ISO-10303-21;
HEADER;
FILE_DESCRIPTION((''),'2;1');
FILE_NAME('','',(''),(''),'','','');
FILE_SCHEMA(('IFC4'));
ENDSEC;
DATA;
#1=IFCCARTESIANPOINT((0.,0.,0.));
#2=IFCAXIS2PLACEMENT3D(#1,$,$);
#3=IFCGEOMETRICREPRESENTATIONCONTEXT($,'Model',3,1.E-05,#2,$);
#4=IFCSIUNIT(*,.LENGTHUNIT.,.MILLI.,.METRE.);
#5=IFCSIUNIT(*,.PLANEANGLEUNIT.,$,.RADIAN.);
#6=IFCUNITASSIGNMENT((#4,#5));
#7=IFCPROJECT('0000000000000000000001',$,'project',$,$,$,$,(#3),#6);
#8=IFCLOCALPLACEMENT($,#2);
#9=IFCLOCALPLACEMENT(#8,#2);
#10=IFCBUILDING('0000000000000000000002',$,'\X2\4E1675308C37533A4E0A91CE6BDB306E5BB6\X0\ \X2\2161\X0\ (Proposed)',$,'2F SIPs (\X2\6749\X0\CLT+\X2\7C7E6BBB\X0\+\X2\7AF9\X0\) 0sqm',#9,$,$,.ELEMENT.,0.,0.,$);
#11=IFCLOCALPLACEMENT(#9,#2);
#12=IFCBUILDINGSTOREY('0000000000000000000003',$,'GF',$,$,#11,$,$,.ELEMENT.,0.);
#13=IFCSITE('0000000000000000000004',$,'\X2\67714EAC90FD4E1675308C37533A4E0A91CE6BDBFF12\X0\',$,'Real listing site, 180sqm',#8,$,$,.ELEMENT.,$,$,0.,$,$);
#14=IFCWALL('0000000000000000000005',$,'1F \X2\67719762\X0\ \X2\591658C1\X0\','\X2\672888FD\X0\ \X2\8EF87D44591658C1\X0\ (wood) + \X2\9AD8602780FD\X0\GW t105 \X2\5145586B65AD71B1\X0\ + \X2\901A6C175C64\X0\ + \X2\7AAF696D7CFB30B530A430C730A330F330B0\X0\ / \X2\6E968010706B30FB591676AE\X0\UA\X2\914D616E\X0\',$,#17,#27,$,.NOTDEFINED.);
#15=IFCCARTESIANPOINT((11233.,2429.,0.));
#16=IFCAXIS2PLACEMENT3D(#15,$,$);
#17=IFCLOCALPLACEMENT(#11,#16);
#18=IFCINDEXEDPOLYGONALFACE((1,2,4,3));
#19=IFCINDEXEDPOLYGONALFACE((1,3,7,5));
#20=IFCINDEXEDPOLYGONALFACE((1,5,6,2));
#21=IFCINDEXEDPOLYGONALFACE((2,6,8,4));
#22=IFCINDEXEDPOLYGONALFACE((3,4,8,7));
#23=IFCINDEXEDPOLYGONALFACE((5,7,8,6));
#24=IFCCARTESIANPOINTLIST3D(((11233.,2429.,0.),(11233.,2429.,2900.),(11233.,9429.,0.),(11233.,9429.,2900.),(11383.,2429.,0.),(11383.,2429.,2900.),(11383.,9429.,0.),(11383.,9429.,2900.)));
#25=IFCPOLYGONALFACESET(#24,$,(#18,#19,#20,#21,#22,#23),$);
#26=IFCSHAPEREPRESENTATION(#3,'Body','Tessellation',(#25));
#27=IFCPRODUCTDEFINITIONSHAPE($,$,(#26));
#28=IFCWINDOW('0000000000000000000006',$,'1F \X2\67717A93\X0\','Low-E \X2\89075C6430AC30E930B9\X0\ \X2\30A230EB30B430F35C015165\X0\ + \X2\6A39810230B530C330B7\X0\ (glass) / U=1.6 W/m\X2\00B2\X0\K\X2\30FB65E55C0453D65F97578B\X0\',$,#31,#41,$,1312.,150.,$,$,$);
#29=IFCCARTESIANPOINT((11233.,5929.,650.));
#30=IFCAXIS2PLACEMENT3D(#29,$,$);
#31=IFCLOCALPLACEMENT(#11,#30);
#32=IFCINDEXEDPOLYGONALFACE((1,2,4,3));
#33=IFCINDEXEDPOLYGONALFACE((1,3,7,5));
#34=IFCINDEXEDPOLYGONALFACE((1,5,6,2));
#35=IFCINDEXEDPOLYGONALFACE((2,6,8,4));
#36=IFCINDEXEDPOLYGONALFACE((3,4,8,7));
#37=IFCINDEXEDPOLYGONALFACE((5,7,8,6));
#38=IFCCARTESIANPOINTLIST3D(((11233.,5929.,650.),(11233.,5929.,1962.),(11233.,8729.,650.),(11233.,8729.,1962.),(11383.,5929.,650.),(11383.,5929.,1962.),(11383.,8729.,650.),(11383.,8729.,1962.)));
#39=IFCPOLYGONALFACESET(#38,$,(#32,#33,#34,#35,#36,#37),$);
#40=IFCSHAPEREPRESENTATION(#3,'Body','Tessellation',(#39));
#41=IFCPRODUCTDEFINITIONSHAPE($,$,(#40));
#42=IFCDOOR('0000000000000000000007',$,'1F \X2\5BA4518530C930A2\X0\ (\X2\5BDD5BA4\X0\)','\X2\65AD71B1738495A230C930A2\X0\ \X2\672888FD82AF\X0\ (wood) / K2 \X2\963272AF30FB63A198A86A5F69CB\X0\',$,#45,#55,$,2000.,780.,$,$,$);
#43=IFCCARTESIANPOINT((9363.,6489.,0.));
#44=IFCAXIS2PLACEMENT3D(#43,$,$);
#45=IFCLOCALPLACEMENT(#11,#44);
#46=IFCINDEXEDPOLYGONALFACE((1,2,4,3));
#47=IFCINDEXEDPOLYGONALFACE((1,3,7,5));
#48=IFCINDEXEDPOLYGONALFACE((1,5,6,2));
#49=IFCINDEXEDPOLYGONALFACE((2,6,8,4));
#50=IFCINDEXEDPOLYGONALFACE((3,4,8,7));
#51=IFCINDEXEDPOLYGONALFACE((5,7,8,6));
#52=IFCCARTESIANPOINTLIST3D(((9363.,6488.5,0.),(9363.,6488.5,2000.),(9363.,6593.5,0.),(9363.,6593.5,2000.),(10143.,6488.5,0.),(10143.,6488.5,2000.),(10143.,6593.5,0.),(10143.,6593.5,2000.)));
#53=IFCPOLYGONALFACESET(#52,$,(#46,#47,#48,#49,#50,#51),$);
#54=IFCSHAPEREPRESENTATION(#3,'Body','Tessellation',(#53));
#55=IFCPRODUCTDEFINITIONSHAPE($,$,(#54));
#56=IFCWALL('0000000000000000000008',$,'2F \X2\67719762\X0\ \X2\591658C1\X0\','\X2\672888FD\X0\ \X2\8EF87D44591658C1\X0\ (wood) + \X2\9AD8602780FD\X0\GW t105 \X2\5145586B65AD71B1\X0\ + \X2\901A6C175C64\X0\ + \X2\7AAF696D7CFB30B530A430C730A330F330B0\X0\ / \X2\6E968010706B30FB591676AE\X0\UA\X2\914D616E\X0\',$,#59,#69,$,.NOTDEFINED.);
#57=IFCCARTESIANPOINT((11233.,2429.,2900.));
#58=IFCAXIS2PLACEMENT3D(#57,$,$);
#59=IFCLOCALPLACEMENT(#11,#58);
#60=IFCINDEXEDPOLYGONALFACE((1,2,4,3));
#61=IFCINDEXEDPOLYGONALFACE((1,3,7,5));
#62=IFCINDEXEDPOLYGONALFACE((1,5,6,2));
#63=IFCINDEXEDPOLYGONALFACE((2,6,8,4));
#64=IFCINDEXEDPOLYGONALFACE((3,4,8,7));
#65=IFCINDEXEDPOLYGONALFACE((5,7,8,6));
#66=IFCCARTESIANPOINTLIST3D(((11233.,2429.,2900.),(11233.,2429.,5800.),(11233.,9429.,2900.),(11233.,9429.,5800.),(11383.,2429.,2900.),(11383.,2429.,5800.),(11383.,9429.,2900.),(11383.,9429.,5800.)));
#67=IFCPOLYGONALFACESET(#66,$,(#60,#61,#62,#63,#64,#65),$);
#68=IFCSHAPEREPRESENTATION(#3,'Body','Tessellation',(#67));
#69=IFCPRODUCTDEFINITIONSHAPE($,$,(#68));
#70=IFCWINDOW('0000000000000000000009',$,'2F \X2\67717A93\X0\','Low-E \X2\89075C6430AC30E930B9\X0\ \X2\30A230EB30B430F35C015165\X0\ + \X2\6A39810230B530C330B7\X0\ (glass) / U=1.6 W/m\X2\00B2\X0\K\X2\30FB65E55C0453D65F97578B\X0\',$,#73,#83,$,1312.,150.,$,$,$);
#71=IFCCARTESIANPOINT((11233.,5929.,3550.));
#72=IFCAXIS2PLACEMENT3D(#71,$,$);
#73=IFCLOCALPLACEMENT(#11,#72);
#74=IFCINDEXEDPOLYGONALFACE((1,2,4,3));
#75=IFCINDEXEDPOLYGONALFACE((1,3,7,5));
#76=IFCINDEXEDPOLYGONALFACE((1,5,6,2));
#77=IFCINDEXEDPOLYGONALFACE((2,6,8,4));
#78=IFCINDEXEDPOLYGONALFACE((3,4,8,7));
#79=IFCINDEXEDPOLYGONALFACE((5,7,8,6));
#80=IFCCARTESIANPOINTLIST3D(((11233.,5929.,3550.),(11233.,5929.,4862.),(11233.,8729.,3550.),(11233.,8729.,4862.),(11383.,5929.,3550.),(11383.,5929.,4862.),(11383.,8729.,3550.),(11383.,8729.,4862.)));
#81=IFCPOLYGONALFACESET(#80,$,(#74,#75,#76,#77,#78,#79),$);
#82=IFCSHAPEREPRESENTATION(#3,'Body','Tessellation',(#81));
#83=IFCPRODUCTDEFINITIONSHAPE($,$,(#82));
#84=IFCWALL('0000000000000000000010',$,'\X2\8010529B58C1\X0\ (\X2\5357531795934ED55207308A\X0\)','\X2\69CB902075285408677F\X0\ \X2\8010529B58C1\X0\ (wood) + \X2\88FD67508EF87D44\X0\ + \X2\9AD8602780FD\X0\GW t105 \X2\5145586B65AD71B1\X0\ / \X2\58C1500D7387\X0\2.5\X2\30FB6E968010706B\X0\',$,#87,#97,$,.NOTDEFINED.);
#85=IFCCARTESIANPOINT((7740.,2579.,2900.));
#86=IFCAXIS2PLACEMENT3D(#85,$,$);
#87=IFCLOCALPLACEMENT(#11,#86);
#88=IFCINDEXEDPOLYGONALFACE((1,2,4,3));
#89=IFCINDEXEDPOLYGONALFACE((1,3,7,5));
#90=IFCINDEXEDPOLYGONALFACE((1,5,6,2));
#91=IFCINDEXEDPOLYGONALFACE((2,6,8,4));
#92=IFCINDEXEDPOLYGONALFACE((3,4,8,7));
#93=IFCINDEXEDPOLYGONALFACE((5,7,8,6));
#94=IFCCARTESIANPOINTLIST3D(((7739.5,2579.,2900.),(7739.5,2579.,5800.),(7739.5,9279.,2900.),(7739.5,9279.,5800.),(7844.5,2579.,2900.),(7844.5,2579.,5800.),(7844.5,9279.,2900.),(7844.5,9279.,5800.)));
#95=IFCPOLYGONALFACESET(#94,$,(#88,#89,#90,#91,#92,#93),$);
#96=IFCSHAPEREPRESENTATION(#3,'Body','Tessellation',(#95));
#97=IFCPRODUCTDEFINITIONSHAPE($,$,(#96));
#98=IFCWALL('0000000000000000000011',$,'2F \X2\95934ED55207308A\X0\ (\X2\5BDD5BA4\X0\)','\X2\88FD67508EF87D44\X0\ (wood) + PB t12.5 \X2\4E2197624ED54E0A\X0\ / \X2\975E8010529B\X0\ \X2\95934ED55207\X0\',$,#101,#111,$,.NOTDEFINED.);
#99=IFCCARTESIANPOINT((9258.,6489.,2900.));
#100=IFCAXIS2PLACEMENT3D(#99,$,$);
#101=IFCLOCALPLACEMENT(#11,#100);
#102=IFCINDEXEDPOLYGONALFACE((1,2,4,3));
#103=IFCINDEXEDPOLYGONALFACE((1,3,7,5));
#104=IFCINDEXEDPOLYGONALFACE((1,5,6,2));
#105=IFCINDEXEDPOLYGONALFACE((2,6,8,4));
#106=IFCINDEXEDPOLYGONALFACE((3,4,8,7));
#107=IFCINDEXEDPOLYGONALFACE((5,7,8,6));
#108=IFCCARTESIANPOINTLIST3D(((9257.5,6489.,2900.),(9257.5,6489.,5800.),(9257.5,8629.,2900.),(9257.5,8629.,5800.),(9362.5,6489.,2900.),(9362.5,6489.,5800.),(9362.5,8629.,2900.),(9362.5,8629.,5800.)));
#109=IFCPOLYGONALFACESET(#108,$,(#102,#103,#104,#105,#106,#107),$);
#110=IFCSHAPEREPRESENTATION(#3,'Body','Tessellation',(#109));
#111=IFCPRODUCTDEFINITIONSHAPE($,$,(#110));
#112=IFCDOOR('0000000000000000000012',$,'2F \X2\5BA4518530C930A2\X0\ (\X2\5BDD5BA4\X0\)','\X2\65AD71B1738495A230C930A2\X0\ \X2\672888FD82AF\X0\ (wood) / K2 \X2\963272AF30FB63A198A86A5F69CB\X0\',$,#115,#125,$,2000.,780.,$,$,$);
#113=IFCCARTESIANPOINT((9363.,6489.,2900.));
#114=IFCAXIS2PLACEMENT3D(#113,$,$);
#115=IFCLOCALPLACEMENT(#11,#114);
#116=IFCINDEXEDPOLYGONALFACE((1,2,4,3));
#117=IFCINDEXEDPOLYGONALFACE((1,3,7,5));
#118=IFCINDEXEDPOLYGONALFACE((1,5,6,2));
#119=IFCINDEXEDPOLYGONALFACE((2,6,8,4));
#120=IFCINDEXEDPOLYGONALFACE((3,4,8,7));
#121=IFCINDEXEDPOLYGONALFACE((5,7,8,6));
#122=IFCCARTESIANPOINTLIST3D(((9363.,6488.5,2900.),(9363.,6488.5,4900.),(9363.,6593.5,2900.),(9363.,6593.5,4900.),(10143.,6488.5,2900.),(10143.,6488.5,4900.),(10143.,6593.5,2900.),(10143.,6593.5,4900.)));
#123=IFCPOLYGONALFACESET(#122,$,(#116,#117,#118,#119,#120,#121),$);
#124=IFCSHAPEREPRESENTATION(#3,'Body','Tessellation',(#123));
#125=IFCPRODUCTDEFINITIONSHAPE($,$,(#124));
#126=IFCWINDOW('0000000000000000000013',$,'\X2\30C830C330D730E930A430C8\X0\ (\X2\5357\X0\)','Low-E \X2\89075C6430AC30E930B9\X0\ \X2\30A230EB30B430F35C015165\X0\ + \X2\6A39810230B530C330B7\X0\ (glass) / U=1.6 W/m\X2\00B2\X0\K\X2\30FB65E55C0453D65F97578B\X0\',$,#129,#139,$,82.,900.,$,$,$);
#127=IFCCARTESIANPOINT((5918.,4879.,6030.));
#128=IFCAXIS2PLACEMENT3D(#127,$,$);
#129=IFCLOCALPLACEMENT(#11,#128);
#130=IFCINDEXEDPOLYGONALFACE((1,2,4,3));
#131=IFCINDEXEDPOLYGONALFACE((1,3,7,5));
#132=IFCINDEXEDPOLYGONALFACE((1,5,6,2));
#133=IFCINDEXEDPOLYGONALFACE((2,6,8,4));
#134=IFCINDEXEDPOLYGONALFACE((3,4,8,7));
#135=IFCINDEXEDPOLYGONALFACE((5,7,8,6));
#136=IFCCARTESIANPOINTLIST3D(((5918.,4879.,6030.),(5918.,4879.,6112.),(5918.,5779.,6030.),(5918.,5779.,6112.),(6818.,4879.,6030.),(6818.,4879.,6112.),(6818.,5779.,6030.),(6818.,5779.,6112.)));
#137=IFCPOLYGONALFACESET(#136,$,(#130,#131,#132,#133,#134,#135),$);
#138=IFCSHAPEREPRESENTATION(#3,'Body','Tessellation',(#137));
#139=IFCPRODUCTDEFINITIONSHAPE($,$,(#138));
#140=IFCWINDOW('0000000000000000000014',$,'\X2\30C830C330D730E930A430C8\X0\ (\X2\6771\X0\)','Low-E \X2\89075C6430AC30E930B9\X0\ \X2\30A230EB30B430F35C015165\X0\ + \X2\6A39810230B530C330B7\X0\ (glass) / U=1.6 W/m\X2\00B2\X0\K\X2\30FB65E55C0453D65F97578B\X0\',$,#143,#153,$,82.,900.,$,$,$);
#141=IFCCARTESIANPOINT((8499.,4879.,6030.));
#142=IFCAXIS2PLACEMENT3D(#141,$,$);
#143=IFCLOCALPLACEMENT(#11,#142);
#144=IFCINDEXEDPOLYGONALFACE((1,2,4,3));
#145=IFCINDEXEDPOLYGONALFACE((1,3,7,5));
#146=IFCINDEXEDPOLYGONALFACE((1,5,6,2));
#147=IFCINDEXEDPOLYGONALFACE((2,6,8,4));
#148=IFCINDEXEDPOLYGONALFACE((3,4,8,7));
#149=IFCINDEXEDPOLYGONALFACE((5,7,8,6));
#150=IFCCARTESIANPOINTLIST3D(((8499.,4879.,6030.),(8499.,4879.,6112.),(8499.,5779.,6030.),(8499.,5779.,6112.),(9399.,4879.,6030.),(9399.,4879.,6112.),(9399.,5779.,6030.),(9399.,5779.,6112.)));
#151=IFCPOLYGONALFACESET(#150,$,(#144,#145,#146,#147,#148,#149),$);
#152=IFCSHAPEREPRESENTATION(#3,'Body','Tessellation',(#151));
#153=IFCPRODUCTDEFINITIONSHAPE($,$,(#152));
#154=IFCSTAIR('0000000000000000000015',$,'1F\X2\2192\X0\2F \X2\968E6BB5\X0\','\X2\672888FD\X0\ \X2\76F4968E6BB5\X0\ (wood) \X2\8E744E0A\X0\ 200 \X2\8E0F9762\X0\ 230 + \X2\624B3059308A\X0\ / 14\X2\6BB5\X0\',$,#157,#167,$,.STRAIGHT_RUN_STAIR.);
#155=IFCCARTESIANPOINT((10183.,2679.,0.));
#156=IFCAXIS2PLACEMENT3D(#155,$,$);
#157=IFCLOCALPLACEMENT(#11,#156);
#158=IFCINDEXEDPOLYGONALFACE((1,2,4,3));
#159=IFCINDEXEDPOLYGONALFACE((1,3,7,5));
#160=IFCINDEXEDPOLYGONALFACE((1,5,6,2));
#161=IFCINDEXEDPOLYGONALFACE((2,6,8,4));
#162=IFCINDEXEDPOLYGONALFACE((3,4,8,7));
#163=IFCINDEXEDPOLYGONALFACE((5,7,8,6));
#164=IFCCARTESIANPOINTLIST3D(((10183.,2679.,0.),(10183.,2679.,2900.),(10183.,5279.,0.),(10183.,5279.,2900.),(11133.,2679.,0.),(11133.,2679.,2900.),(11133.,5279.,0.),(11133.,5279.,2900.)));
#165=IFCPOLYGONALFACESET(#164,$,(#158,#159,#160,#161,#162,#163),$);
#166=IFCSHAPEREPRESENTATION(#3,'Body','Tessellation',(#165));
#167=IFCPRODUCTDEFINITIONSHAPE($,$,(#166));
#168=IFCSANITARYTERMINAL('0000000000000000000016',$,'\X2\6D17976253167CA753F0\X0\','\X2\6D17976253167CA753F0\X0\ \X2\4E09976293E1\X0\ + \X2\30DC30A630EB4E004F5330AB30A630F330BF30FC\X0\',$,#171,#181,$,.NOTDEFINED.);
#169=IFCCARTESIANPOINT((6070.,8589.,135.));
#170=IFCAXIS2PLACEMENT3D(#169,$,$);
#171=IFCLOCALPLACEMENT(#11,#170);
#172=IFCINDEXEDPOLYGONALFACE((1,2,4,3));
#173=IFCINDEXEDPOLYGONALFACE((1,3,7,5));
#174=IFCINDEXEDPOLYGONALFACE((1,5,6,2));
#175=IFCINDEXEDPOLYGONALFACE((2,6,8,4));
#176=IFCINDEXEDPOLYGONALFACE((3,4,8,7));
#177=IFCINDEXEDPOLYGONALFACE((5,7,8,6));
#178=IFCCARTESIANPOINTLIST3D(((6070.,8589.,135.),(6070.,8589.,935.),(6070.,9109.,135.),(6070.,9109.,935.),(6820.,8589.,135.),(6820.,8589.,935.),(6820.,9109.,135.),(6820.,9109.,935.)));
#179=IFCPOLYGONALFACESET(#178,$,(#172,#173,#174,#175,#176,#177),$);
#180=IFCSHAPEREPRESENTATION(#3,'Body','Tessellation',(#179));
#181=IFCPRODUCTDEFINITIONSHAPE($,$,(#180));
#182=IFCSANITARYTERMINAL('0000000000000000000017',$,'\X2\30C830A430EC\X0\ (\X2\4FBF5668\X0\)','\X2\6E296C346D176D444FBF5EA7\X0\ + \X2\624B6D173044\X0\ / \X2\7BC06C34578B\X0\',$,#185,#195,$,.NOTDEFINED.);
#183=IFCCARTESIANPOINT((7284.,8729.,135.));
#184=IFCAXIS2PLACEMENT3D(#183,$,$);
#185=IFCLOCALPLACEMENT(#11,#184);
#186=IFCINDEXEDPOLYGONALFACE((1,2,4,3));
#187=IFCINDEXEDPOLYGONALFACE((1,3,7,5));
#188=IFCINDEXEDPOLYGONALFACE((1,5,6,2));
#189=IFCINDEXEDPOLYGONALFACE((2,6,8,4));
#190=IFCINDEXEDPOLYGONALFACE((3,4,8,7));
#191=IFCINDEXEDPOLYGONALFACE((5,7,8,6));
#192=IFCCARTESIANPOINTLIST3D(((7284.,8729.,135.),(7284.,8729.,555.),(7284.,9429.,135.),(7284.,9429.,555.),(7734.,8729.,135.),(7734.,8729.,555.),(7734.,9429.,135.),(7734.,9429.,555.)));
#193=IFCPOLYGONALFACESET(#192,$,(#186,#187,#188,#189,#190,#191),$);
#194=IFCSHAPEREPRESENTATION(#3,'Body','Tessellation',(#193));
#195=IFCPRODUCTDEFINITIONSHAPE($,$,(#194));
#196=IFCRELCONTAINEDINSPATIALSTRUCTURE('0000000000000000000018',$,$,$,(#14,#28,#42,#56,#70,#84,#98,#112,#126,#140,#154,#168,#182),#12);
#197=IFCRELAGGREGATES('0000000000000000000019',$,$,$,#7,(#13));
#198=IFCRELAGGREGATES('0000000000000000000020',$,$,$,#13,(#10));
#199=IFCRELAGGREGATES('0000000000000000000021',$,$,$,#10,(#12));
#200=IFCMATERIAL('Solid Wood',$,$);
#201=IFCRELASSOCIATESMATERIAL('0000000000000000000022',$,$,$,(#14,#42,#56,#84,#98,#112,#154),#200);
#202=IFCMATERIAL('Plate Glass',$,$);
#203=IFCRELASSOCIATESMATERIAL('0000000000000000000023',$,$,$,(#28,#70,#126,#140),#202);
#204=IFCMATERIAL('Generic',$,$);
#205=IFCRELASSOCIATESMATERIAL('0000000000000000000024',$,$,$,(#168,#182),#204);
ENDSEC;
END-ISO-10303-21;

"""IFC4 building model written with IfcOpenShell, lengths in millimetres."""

from ifc_helpers import new_model, si_unit, frame, frame_2d, origin, place, context, project, spatial, rectangle, extrude, material, element, fill, save


model = new_model("IFC4")

# Units and contexts
model_context = context("Model", 3, precision=1e-05, world=origin())
ifc_project = project(units=[si_unit("LENGTHUNIT", "METRE", prefix="MILLI"), si_unit("PLANEANGLEUNIT", "RADIAN")], contexts=[model_context])

# Site, building, storey
site_placement = place(None, origin())
site = spatial("IfcSite", under=ifc_project, at=site_placement, Name="東京都世田谷区上野毛２", ObjectType="Real listing site, 180sqm", CompositionType="ELEMENT", RefElevation=0.0)
building_placement = place(site_placement, origin())
building = spatial("IfcBuilding", under=site, at=building_placement, Name="世田谷区上野毛の家 Ⅱ (Proposed)", ObjectType="2F SIPs (杉CLT+籾殻+竹) 0sqm", CompositionType="ELEMENT", ElevationOfRefHeight=0.0, ElevationOfTerrain=0.0)
storey_placement = place(building_placement, origin())
storey = spatial("IfcBuildingStorey", under=building, at=storey_placement, Name="GF", CompositionType="ELEMENT", Elevation=0.0)

# Wall, opening, window
ifc_material_1 = material(Name="Solid Wood")
wall_1_placement = place(storey_placement, frame((11233.0, 2429.0, 0.0)))
wall_1 = element("IfcWall", 1, at=wall_1_placement, inside=storey, material=ifc_material_1, Name="1F 東面 外壁", Description="木製 軸組外壁 (wood) + 高性能GW t105 充填断熱 + 通気層 + 窯業系サイディング / 準耐火・外皮UA配慮", PredefinedType="NOTDEFINED", context=model_context, shape_type="SweptSolid", body=[
    extrude(rectangle(XDim=150.0, YDim=7000.0, at=frame_2d((75.0, 3500.0))), frame((11233.0, 2429.0, 0.0)), (0.0, 0.0, 1.0), 2900.0),
])
opening_1_placement = place(storey_placement, frame((11233.0, 5929.0, 650.0)))
opening_1 = element("IfcOpeningElement", 2, at=opening_1_placement, cuts=wall_1, PredefinedType="NOTDEFINED", context=model_context, shape_type="SweptSolid", body=[
    extrude(rectangle(XDim=150.0, YDim=2800.0, at=frame_2d((75.0, 1400.0))), frame((11233.0, 5929.0, 650.0)), (0.0, 0.0, 1.0), 1312.0),
])
ifc_material_2 = material(Name="Plate Glass")
window_1_placement = place(storey_placement, frame((11233.0, 5929.0, 650.0)))
window_1 = element("IfcWindow", 3, at=window_1_placement, inside=storey, material=ifc_material_2, Name="1F 東窓", Description="Low-E 複層ガラス アルゴン封入 + 樹脂サッシ (glass) / U=1.6 W/m²K・日射取得型", OverallHeight=1312.0, OverallWidth=150.0, context=model_context, shape_type="SweptSolid", body=[
    extrude(rectangle(XDim=150.0, YDim=2800.0, at=frame_2d((75.0, 1400.0))), frame((11233.0, 5929.0, 650.0)), (0.0, 0.0, 1.0), 1312.0),
])
fill(opening_1, window_1)

# Door
door_1_placement = place(storey_placement, frame((9363.0, 6489.0, 0.0)))
element("IfcDoor", 4, at=door_1_placement, inside=storey, material=ifc_material_1, Name="1F 室内ドア (寝室)", Description="断熱玄関ドア 木製芯 (wood) / K2 防犯・採風機構", OverallHeight=2000.0, OverallWidth=780.0, context=model_context, shape_type="SweptSolid", body=[
    extrude(rectangle(XDim=780.0, YDim=105.0, at=frame_2d((390.0, 52.0))), frame((9363.0, 6489.0, 0.0)), (0.0, 0.0, 1.0), 2000.0),
])

# Wall, opening, window
wall_2_placement = place(storey_placement, frame((11233.0, 2429.0, 2900.0)))
wall_2 = element("IfcWall", 5, at=wall_2_placement, inside=storey, material=ifc_material_1, Name="2F 東面 外壁", Description="木製 軸組外壁 (wood) + 高性能GW t105 充填断熱 + 通気層 + 窯業系サイディング / 準耐火・外皮UA配慮", PredefinedType="NOTDEFINED", context=model_context, shape_type="SweptSolid", body=[
    extrude(rectangle(XDim=150.0, YDim=7000.0, at=frame_2d((75.0, 3500.0))), frame((11233.0, 2429.0, 2900.0)), (0.0, 0.0, 1.0), 2900.0),
])
opening_2_placement = place(storey_placement, frame((11233.0, 5929.0, 3550.0)))
opening_2 = element("IfcOpeningElement", 6, at=opening_2_placement, cuts=wall_2, PredefinedType="NOTDEFINED", context=model_context, shape_type="SweptSolid", body=[
    extrude(rectangle(XDim=150.0, YDim=2800.0, at=frame_2d((75.0, 1400.0))), frame((11233.0, 5929.0, 3550.0)), (0.0, 0.0, 1.0), 1312.0),
])
window_2_placement = place(storey_placement, frame((11233.0, 5929.0, 3550.0)))
window_2 = element("IfcWindow", 7, at=window_2_placement, inside=storey, material=ifc_material_2, Name="2F 東窓", Description="Low-E 複層ガラス アルゴン封入 + 樹脂サッシ (glass) / U=1.6 W/m²K・日射取得型", OverallHeight=1312.0, OverallWidth=150.0, context=model_context, shape_type="SweptSolid", body=[
    extrude(rectangle(XDim=150.0, YDim=2800.0, at=frame_2d((75.0, 1400.0))), frame((11233.0, 5929.0, 3550.0)), (0.0, 0.0, 1.0), 1312.0),
])
fill(opening_2, window_2)

# Walls
wall_3_placement = place(storey_placement, frame((7740.0, 2579.0, 2900.0)))
element("IfcWall", 8, at=wall_3_placement, inside=storey, material=ifc_material_1, Name="耐力壁 (南北間仕切り)", Description="構造用合板 耐力壁 (wood) + 製材軸組 + 高性能GW t105 充填断熱 / 壁倍率2.5・準耐火", PredefinedType="NOTDEFINED", context=model_context, shape_type="SweptSolid", body=[
    extrude(rectangle(XDim=105.0, YDim=6700.0, at=frame_2d((52.0, 3350.0))), frame((7740.0, 2579.0, 2900.0)), (0.0, 0.0, 1.0), 2900.0),
])
wall_4_placement = place(storey_placement, frame((9258.0, 6489.0, 2900.0)))
element("IfcWall", 9, at=wall_4_placement, inside=storey, material=ifc_material_1, Name="2F 間仕切り (寝室)", Description="製材軸組 (wood) + PB t12.5 両面仕上 / 非耐力 間仕切", PredefinedType="NOTDEFINED", context=model_context, shape_type="SweptSolid", body=[
    extrude(rectangle(XDim=105.0, YDim=2140.0, at=frame_2d((52.0, 1070.0))), frame((9258.0, 6489.0, 2900.0)), (0.0, 0.0, 1.0), 2900.0),
])

# Door
door_2_placement = place(storey_placement, frame((9363.0, 6489.0, 2900.0)))
element("IfcDoor", 10, at=door_2_placement, inside=storey, material=ifc_material_1, Name="2F 室内ドア (寝室)", Description="断熱玄関ドア 木製芯 (wood) / K2 防犯・採風機構", OverallHeight=2000.0, OverallWidth=780.0, context=model_context, shape_type="SweptSolid", body=[
    extrude(rectangle(XDim=780.0, YDim=105.0, at=frame_2d((390.0, 52.0))), frame((9363.0, 6489.0, 2900.0)), (0.0, 0.0, 1.0), 2000.0),
])

# Windows
window_3_placement = place(storey_placement, frame((5918.0, 4879.0, 6030.0)))
element("IfcWindow", 11, at=window_3_placement, inside=storey, material=ifc_material_2, Name="トップライト (南)", Description="Low-E 複層ガラス アルゴン封入 + 樹脂サッシ (glass) / U=1.6 W/m²K・日射取得型", OverallHeight=82.0, OverallWidth=900.0, context=model_context, shape_type="SweptSolid", body=[
    extrude(rectangle(XDim=900.0, YDim=900.0, at=frame_2d((450.0, 450.0))), frame((5918.0, 4879.0, 6030.0)), (0.0, 0.0, 1.0), 82.0),
])
window_4_placement = place(storey_placement, frame((8499.0, 4879.0, 6030.0)))
element("IfcWindow", 12, at=window_4_placement, inside=storey, material=ifc_material_2, Name="トップライト (東)", Description="Low-E 複層ガラス アルゴン封入 + 樹脂サッシ (glass) / U=1.6 W/m²K・日射取得型", OverallHeight=82.0, OverallWidth=900.0, context=model_context, shape_type="SweptSolid", body=[
    extrude(rectangle(XDim=900.0, YDim=900.0, at=frame_2d((450.0, 450.0))), frame((8499.0, 4879.0, 6030.0)), (0.0, 0.0, 1.0), 82.0),
])

# Stair
stair_placement = place(storey_placement, frame((10183.0, 2679.0, 0.0)))
element("IfcStair", 13, at=stair_placement, inside=storey, material=ifc_material_1, Name="1F→2F 階段", Description="木製 直階段 (wood) 蹴上 200 踏面 230 + 手すり / 14段", PredefinedType="STRAIGHT_RUN_STAIR", context=model_context, shape_type="SweptSolid", body=[
    extrude(rectangle(XDim=950.0, YDim=2600.0, at=frame_2d((475.0, 1300.0))), frame((10183.0, 2679.0, 0.0)), (0.0, 0.0, 1.0), 2900.0),
])

# Sanitary terminals
ifc_material_3 = material(Name="Generic")
sanitary_terminal_1_placement = place(storey_placement, frame((6070.0, 8589.0, 135.0)))
element("IfcSanitaryTerminal", 14, at=sanitary_terminal_1_placement, inside=storey, material=ifc_material_3, Name="洗面化粧台", Description="洗面化粧台 三面鏡 + ボウル一体カウンター", PredefinedType="NOTDEFINED", context=model_context, shape_type="SweptSolid", body=[
    extrude(rectangle(XDim=750.0, YDim=520.0, at=frame_2d((375.0, 260.0))), frame((6070.0, 8589.0, 135.0)), (0.0, 0.0, 1.0), 800.0),
])
sanitary_terminal_2_placement = place(storey_placement, frame((7284.0, 8729.0, 135.0)))
element("IfcSanitaryTerminal", 15, at=sanitary_terminal_2_placement, inside=storey, material=ifc_material_3, Name="トイレ (便器)", Description="温水洗浄便座 + 手洗い / 節水型", PredefinedType="NOTDEFINED", context=model_context, shape_type="SweptSolid", body=[
    extrude(rectangle(XDim=450.0, YDim=700.0, at=frame_2d((225.0, 350.0))), frame((7284.0, 8729.0, 135.0)), (0.0, 0.0, 1.0), 420.0),
])

save(model, "model.ifc")
